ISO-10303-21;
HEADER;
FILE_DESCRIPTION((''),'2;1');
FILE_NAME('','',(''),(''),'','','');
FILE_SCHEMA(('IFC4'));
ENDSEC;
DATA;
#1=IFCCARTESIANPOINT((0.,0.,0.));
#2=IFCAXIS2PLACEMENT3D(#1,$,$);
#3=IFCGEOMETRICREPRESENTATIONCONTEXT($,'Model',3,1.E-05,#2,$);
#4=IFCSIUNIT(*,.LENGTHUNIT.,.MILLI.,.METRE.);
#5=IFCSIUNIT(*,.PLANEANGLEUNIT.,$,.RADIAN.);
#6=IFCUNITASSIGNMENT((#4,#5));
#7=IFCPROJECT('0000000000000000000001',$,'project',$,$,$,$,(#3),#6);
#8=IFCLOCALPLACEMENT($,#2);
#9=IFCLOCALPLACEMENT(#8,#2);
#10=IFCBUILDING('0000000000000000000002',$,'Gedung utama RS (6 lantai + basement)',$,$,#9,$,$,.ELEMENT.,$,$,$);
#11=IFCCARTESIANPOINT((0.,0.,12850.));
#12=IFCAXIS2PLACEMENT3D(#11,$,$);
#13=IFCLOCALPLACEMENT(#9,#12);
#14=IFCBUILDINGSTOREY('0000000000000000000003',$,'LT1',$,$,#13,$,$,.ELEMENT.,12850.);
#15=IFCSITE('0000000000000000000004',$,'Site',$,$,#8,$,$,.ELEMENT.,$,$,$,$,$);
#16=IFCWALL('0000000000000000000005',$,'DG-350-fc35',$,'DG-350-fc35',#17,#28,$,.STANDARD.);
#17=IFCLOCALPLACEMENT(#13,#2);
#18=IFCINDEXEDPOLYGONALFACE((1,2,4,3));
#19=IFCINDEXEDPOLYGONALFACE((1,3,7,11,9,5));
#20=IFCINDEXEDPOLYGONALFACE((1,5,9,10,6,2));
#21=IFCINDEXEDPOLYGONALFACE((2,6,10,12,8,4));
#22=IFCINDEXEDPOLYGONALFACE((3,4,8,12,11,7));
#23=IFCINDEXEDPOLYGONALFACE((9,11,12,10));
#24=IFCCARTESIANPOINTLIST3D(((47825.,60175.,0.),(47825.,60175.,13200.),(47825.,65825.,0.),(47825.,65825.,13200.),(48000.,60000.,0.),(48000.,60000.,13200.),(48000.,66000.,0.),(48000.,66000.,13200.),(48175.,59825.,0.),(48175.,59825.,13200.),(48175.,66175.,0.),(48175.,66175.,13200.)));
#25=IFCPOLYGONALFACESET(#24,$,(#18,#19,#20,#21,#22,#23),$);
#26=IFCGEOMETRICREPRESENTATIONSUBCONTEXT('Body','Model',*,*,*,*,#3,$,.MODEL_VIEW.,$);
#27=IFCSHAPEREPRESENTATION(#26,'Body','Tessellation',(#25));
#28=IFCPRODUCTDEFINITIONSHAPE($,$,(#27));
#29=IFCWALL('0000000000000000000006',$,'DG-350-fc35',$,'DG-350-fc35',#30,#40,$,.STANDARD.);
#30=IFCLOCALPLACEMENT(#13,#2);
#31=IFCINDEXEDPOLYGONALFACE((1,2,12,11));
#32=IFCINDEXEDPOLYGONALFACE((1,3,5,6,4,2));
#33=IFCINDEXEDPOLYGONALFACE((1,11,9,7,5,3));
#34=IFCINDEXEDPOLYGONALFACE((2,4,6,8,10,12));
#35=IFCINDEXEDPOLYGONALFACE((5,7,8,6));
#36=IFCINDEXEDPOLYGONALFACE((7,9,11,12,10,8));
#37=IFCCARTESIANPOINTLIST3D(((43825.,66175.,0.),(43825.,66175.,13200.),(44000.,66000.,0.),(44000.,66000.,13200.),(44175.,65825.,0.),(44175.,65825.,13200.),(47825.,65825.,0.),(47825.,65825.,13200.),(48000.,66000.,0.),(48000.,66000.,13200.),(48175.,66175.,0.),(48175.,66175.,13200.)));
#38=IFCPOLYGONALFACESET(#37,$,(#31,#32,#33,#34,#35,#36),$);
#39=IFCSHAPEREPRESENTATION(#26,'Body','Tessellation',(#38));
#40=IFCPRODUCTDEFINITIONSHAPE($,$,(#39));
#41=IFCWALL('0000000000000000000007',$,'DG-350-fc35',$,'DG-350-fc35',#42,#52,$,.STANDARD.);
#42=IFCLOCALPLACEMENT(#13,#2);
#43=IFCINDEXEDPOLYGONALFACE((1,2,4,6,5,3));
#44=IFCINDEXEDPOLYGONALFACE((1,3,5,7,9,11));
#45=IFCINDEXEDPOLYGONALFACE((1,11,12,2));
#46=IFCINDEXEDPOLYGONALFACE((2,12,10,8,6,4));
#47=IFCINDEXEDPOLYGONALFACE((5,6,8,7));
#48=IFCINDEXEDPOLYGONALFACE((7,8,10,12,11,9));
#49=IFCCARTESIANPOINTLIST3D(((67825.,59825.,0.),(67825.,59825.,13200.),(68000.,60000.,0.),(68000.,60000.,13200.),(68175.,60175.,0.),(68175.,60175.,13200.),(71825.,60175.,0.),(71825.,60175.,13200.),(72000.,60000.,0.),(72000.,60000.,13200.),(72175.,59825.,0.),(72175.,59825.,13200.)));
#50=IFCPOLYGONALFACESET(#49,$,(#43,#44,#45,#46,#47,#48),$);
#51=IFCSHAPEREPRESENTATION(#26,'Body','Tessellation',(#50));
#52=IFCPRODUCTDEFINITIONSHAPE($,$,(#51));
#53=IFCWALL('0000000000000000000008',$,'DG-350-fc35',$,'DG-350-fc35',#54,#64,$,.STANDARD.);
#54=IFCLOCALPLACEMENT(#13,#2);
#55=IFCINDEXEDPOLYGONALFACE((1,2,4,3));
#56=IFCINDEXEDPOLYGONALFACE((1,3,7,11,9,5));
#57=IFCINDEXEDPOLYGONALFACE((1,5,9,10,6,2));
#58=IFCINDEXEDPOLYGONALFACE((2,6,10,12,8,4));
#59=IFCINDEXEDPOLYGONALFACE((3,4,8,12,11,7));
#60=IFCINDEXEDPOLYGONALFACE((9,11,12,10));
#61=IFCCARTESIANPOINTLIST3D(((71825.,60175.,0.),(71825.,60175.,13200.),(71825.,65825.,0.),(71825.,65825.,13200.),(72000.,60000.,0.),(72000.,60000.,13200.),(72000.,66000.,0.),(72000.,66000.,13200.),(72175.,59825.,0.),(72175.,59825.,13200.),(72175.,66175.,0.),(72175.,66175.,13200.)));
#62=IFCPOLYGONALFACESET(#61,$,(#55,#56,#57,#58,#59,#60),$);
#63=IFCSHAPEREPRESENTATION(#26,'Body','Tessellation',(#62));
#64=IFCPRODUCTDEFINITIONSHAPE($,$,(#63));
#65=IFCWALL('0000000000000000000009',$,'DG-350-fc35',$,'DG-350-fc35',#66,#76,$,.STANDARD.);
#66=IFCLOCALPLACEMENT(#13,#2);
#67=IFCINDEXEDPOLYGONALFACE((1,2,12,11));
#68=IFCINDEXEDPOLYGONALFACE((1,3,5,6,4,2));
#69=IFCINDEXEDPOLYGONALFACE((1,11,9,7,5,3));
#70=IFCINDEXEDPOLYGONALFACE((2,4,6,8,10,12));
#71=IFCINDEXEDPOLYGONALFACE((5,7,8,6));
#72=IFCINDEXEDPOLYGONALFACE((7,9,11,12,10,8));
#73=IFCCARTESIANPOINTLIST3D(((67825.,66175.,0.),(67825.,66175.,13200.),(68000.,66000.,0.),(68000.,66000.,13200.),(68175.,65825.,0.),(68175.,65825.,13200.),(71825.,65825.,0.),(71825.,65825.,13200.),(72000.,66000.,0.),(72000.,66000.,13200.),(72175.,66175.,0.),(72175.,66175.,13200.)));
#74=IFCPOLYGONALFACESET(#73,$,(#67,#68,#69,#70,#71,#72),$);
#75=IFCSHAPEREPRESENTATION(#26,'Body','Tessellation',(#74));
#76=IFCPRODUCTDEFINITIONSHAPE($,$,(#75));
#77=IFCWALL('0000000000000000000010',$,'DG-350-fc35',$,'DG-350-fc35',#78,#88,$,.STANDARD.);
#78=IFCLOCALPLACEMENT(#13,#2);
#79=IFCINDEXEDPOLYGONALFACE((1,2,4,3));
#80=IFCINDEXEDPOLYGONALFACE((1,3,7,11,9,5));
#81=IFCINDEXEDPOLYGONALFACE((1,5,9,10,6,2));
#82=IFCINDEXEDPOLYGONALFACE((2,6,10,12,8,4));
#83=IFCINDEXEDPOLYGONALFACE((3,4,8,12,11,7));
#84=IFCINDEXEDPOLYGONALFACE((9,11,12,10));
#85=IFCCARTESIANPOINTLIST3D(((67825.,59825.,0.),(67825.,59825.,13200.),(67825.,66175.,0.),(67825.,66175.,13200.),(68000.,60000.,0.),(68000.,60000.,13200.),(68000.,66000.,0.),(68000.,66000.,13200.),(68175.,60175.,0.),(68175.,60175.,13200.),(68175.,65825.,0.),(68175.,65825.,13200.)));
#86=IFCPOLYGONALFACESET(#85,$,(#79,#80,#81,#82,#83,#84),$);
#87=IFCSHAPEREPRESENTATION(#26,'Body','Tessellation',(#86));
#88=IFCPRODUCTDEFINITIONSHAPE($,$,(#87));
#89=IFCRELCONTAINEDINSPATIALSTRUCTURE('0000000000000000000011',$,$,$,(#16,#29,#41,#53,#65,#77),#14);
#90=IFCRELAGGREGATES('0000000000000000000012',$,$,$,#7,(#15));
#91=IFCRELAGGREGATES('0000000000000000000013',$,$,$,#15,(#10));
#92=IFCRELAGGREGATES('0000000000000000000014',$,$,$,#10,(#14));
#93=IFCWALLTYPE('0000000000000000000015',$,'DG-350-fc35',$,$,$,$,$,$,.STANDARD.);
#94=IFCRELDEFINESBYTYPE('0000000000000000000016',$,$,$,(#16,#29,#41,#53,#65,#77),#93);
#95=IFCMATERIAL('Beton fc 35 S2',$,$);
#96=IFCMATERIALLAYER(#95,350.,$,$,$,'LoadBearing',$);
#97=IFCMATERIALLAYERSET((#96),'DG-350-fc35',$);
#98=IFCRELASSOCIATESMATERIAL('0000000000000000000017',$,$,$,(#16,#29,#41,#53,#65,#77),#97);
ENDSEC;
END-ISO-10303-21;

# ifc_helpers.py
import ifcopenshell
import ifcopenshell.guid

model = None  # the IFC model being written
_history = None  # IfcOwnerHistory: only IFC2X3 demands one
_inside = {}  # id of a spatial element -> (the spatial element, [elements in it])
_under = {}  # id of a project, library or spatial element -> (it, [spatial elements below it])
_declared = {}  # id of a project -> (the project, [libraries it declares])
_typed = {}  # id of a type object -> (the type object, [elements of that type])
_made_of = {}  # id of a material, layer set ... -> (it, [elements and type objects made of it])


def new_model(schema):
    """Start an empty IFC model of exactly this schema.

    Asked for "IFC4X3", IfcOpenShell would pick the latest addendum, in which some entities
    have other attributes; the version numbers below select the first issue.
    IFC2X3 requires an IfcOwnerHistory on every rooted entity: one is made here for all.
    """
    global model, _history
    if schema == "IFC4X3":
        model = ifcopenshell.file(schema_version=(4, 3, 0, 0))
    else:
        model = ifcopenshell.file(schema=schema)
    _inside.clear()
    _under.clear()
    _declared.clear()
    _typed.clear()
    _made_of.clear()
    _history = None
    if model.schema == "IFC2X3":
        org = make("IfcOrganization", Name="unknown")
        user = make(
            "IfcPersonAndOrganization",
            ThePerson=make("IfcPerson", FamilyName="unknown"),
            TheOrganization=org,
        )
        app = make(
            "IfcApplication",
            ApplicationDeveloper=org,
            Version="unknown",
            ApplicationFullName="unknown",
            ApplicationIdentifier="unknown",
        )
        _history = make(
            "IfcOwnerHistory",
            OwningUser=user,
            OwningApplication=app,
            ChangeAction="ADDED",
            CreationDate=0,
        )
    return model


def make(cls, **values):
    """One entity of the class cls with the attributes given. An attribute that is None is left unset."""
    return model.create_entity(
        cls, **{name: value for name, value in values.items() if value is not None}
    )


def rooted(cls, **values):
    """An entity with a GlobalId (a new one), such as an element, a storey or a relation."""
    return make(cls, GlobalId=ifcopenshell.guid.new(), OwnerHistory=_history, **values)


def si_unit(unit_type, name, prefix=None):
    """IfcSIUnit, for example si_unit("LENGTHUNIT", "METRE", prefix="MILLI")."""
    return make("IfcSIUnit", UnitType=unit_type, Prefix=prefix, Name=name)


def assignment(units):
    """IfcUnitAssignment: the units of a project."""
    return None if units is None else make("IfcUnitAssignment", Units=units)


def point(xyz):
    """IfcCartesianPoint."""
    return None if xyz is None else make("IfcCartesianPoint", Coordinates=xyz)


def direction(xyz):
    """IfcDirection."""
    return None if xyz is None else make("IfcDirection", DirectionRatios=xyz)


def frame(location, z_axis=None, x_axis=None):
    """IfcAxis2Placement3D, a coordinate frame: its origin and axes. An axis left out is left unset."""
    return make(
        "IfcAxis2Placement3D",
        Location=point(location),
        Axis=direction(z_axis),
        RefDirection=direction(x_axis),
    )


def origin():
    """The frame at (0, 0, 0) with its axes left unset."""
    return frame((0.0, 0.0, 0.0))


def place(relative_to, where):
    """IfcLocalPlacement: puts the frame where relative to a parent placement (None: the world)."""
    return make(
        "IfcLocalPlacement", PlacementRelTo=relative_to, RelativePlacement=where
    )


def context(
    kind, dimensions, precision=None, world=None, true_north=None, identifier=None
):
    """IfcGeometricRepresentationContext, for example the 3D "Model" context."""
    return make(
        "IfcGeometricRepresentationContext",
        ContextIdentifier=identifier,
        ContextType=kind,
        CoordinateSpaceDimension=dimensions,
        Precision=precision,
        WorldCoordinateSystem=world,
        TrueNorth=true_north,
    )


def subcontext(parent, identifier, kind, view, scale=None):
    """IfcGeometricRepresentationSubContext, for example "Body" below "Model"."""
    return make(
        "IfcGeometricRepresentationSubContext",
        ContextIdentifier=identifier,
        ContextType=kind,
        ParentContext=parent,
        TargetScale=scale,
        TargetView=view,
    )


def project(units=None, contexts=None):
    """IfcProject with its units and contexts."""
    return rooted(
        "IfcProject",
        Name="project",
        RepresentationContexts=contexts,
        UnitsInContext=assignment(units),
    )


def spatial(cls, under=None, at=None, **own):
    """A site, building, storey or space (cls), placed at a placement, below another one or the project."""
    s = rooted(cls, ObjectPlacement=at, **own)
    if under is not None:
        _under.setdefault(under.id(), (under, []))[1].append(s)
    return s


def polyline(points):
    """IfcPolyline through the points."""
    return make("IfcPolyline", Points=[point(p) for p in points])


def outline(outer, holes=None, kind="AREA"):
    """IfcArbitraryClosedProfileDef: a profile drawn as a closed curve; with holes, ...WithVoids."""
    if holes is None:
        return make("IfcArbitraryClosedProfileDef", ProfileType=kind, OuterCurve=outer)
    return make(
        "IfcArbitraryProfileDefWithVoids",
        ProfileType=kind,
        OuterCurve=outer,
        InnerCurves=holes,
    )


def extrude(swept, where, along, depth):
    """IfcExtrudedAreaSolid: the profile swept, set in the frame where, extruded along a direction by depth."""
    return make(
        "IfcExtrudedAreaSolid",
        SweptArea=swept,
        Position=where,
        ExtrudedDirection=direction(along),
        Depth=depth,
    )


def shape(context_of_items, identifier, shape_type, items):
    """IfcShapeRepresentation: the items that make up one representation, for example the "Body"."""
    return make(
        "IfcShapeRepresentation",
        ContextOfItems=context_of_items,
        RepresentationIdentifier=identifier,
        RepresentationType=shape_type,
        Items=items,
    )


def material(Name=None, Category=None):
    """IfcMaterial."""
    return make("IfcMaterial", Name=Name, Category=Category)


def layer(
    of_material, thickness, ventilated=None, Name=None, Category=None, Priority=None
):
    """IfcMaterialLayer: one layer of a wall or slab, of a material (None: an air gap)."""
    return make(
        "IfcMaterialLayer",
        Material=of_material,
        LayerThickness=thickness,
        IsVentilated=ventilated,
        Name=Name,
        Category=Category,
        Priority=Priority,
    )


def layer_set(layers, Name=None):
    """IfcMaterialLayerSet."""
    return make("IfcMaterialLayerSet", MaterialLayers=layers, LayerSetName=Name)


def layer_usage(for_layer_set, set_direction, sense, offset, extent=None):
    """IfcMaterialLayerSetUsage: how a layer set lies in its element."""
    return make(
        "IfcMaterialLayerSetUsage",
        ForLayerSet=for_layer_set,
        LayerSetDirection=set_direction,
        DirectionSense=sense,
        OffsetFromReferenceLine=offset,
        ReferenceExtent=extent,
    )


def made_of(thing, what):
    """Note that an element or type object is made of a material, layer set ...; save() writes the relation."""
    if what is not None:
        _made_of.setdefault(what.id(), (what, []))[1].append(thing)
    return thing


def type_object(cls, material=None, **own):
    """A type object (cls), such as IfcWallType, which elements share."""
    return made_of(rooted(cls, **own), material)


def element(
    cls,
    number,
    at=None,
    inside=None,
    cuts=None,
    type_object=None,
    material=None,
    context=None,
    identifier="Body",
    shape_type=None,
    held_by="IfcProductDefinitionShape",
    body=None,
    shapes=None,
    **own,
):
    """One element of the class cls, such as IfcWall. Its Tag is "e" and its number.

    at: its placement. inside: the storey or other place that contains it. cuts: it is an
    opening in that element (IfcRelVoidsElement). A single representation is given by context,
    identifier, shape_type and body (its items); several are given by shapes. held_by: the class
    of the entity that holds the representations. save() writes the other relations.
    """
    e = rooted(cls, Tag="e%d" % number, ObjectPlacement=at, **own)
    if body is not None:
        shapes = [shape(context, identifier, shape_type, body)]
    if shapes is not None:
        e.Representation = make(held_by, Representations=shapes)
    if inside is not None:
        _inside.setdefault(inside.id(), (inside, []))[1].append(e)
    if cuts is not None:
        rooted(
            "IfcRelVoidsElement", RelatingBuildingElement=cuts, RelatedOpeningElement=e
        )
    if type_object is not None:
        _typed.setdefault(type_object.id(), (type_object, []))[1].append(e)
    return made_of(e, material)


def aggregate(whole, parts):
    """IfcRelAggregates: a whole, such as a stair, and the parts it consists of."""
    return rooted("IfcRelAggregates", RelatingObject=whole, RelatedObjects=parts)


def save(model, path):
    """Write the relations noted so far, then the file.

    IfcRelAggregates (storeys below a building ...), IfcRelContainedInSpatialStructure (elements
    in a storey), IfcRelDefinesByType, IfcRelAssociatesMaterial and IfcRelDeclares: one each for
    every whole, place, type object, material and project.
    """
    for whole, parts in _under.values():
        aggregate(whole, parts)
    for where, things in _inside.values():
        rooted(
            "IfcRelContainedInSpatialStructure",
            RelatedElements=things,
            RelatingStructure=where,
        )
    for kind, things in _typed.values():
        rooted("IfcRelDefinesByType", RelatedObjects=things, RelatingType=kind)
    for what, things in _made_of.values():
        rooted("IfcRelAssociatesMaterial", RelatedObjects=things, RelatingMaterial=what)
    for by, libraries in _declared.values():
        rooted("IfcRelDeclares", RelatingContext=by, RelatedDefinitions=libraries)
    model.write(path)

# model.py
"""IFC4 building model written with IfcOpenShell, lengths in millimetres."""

from ifc_helpers import new_model, si_unit, frame, origin, place, context, subcontext, project, spatial, polyline, outline, extrude, material, layer, layer_set, layer_usage, type_object, element, save


model = new_model("IFC4")

# Units and contexts
model_context = context("Model", 3, precision=1e-05, world=origin())
body_context = subcontext(model_context, "Body", "Model", "MODEL_VIEW")
ifc_project = project(units=[si_unit("LENGTHUNIT", "METRE", prefix="MILLI"), si_unit("PLANEANGLEUNIT", "RADIAN")], contexts=[model_context])

# Site, building, storey
site_placement = place(None, origin())
site = spatial("IfcSite", under=ifc_project, at=site_placement, Name="Site", CompositionType="ELEMENT")
building_placement = place(site_placement, origin())
building = spatial("IfcBuilding", under=site, at=building_placement, Name="Gedung utama RS (6 lantai + basement)", CompositionType="ELEMENT")
storey_placement = place(building_placement, frame((0.0, 0.0, 12850.0)))
storey = spatial("IfcBuildingStorey", under=building, at=storey_placement, Name="LT1", CompositionType="ELEMENT", Elevation=12850.0)

# Walls
ifc_material = material(Name="Beton fc 35 S2")
ifc_layer = layer(ifc_material, 350.0, Category="LoadBearing")
ifc_layer_set = layer_set([ifc_layer], Name="DG-350-fc35")
ifc_layer_usage = layer_usage(ifc_layer_set, "AXIS2", "NEGATIVE", 175.0)
wall_type = type_object("IfcWallType", Name="DG-350-fc35", PredefinedType="STANDARD")
wall_1_placement = place(storey_placement, frame((48000.0, 60000.0, 0.0), z_axis=(0.0, 0.0, 1.0), x_axis=(0.0, 1.0, 0.0)))
element("IfcWall", 1, at=wall_1_placement, inside=storey, type_object=wall_type, material=ifc_layer_usage, Name="DG-350-fc35", ObjectType="DG-350-fc35", PredefinedType="STANDARD", context=body_context, shape_type="SweptSolid", body=[
    extrude(outline(polyline([(-175.0, -175.0), (0.0, 0.0), (175.0, 175.0), (5825.0, 175.0), (6000.0, 0.0), (6175.0, -175.0), (-175.0, -175.0)])), origin(), (0.0, 0.0, 1.0), 13200.0),
])
for number, where, z_axis, x_axis, name in (
    (2, (48000.0, 66000.0, 0.0), (0.0, 0.0, 1.0), (-1.0, 0.0, 0.0), "DG-350-fc35"),
    (3, (68000.0, 60000.0, 0.0), (0.0, 0.0, 1.0), (1.0, 0.0, 0.0), "DG-350-fc35"),
):
    element("IfcWall", number, at=place(storey_placement, frame(where, z_axis=z_axis, x_axis=x_axis)), inside=storey, type_object=wall_type, material=ifc_layer_usage, Name=name, ObjectType="DG-350-fc35", PredefinedType="STANDARD", context=body_context, shape_type="SweptSolid", body=[
        extrude(outline(polyline([(-175.0, -175.0), (0.0, 0.0), (175.0, 175.0), (3825.0, 175.0), (4000.0, 0.0), (4175.0, -175.0), (-175.0, -175.0)])), origin(), (0.0, 0.0, 1.0), 13200.0),
    ])
wall_2_placement = place(storey_placement, frame((72000.0, 60000.0, 0.0), z_axis=(0.0, 0.0, 1.0), x_axis=(0.0, 1.0, 0.0)))
element("IfcWall", 4, at=wall_2_placement, inside=storey, type_object=wall_type, material=ifc_layer_usage, Name="DG-350-fc35", ObjectType="DG-350-fc35", PredefinedType="STANDARD", context=body_context, shape_type="SweptSolid", body=[
    extrude(outline(polyline([(-175.0, -175.0), (0.0, 0.0), (175.0, 175.0), (5825.0, 175.0), (6000.0, 0.0), (6175.0, -175.0), (-175.0, -175.0)])), origin(), (0.0, 0.0, 1.0), 13200.0),
])
wall_3_placement = place(storey_placement, frame((72000.0, 66000.0, 0.0), z_axis=(0.0, 0.0, 1.0), x_axis=(-1.0, 0.0, 0.0)))
element("IfcWall", 5, at=wall_3_placement, inside=storey, type_object=wall_type, material=ifc_layer_usage, Name="DG-350-fc35", ObjectType="DG-350-fc35", PredefinedType="STANDARD", context=body_context, shape_type="SweptSolid", body=[
    extrude(outline(polyline([(-175.0, -175.0), (0.0, 0.0), (175.0, 175.0), (3825.0, 175.0), (4000.0, 0.0), (4175.0, -175.0), (-175.0, -175.0)])), origin(), (0.0, 0.0, 1.0), 13200.0),
])
wall_4_placement = place(storey_placement, frame((68000.0, 66000.0, 0.0), z_axis=(0.0, 0.0, 1.0), x_axis=(0.0, -1.0, 0.0)))
element("IfcWall", 6, at=wall_4_placement, inside=storey, type_object=wall_type, material=ifc_layer_usage, Name="DG-350-fc35", ObjectType="DG-350-fc35", PredefinedType="STANDARD", context=body_context, shape_type="SweptSolid", body=[
    extrude(outline(polyline([(-175.0, -175.0), (0.0, 0.0), (175.0, 175.0), (5825.0, 175.0), (6000.0, 0.0), (6175.0, -175.0), (-175.0, -175.0)])), origin(), (0.0, 0.0, 1.0), 13200.0),
])

save(model, "model.ifc")
